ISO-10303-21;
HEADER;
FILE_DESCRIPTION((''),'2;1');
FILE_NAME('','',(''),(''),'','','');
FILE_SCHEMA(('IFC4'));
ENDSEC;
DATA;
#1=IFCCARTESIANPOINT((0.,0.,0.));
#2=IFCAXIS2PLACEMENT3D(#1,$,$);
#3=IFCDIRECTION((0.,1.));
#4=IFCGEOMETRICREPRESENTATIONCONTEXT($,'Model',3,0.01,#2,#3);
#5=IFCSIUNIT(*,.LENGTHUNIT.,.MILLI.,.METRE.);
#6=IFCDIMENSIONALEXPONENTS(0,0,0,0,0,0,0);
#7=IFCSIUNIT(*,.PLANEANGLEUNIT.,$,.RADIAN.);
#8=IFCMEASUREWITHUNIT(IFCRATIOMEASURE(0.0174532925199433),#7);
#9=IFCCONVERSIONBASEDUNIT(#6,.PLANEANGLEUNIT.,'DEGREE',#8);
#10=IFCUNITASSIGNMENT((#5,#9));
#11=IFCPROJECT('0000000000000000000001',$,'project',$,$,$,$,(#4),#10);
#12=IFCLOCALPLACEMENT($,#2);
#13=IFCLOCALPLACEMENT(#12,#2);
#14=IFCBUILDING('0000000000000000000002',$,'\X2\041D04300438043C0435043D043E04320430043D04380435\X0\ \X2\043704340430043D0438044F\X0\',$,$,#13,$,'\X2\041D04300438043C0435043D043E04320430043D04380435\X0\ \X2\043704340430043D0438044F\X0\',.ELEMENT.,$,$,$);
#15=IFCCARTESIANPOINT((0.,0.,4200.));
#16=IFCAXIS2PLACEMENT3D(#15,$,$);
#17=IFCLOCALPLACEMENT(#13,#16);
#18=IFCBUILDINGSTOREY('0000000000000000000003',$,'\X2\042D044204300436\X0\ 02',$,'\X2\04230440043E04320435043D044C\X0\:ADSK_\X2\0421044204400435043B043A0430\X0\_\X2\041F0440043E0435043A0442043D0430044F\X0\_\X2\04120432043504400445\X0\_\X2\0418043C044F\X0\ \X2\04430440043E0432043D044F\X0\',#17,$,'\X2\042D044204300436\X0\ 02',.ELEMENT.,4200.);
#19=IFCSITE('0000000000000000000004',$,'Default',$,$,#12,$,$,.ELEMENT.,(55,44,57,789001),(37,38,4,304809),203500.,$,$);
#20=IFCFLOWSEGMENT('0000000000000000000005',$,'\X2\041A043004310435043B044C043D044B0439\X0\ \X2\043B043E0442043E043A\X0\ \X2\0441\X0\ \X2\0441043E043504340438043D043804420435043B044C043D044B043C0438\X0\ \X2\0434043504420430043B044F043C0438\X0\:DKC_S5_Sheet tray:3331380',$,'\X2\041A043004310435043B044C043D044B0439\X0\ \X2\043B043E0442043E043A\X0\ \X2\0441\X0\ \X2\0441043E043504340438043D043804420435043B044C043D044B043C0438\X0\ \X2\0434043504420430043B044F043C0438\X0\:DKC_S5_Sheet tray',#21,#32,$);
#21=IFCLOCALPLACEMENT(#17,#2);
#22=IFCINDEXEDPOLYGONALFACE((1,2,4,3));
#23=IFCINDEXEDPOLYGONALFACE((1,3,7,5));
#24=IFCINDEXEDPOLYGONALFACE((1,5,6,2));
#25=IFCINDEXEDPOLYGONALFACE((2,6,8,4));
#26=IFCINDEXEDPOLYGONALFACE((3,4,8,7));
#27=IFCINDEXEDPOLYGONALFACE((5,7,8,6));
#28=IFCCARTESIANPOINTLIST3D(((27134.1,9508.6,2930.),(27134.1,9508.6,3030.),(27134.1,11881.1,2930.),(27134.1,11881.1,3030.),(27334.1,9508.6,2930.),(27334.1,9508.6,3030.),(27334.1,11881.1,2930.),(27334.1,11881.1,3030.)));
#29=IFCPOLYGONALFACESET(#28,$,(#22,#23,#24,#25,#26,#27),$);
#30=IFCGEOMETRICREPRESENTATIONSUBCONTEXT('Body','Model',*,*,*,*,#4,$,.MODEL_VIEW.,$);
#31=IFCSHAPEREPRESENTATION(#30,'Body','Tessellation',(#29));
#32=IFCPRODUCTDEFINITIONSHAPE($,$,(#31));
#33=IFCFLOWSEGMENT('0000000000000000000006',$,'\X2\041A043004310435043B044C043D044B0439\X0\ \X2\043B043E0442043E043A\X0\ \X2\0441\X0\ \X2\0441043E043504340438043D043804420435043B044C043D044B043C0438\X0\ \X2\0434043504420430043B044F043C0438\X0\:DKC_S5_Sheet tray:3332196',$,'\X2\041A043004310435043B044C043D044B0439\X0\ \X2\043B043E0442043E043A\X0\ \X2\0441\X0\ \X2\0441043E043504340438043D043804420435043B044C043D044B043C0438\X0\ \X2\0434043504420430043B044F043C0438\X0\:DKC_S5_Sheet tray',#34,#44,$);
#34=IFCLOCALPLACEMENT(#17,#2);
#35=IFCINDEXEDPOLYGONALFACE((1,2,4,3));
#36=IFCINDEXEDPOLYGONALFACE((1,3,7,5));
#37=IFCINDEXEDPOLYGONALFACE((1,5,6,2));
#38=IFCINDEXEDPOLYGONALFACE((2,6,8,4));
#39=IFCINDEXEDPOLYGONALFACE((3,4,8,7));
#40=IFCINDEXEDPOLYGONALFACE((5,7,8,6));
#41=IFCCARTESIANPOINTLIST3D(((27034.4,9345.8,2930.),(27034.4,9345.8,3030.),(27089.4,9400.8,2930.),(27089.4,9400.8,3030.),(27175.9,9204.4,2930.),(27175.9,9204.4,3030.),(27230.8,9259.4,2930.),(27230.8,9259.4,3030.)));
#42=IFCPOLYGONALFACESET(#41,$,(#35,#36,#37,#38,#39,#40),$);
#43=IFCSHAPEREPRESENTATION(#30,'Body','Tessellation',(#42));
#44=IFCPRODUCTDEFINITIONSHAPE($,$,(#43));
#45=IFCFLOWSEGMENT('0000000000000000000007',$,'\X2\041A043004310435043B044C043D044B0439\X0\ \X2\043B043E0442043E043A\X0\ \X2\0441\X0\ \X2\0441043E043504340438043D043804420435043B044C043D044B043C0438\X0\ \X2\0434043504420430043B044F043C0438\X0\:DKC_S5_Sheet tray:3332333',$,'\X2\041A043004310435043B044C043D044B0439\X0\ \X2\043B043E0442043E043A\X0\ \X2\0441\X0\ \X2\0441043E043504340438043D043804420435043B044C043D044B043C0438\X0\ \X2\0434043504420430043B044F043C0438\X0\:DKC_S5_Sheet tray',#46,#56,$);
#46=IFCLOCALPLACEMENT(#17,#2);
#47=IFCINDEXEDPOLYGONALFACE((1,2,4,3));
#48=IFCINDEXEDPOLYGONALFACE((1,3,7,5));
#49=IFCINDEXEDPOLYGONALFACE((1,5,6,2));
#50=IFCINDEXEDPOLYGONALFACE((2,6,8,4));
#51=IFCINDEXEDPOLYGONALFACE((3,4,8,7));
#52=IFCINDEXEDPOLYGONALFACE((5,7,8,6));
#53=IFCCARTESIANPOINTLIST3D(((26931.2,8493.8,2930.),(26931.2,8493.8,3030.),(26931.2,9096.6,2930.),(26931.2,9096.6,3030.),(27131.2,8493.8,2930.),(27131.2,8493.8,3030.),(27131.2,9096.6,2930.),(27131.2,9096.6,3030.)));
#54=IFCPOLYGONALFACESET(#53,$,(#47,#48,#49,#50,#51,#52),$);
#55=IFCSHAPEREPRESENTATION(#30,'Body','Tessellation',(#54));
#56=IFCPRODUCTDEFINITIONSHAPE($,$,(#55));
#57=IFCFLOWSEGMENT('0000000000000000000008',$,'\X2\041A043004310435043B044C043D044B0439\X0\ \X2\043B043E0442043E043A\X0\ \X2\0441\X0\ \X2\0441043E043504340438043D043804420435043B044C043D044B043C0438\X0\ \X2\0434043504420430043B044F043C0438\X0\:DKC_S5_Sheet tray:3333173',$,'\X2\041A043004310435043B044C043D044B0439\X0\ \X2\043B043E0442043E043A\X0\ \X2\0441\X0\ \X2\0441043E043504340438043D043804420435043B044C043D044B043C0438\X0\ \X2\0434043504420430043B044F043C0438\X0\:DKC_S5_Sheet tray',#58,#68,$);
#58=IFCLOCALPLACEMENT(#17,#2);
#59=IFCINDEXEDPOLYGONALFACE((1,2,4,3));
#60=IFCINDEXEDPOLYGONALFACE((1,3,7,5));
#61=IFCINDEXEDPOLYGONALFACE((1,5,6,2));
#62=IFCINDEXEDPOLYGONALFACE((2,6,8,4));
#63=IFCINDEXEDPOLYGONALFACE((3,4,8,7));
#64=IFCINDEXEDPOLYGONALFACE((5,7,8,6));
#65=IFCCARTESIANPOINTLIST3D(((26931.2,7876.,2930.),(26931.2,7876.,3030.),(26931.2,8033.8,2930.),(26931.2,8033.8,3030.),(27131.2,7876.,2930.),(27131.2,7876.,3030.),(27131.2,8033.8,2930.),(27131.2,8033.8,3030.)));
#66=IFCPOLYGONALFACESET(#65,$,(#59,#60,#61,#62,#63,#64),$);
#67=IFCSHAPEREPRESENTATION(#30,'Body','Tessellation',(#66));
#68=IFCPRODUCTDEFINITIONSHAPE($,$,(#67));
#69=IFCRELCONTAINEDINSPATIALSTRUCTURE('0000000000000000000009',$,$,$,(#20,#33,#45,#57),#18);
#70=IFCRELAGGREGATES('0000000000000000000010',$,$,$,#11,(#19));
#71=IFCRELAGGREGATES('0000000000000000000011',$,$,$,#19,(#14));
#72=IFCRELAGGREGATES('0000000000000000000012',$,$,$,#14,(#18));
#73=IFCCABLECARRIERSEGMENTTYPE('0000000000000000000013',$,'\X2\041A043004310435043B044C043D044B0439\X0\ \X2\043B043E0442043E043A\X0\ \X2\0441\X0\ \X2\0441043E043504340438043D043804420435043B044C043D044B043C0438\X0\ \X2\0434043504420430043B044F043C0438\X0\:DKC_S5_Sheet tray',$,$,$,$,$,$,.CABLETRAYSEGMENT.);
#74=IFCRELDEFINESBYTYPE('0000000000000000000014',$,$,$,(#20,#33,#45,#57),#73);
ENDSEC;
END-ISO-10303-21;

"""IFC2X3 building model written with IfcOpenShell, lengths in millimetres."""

from ifc_helpers import new_model, entity, si_unit, converted_unit, direction, frame, frame_2d, origin, origin_2d_with_axis, place, context, subcontext, project, spatial, rectangle, extrude, type_object, element, save


model = new_model("IFC2X3")

# Units and contexts
model_context = context("Model", 3, precision=0.01, world=origin(), true_north=direction((0.0, 1.0)))
body_context = subcontext(model_context, "Body", "Model", "MODEL_VIEW")
ifc_project = project(units=[si_unit("LENGTHUNIT", "METRE", prefix="MILLI"), converted_unit("PLANEANGLEUNIT", "DEGREE", entity("IfcRatioMeasure", 0.0174532925199433), si_unit("PLANEANGLEUNIT", "RADIAN"), dimensions=[0, 0, 0, 0, 0, 0, 0])], contexts=[model_context])

# Site, building, storey
site_placement = place(None, frame((0.0, 0.0, 0.0)))
site = spatial("IfcSite", under=ifc_project, at=site_placement, Name="Default", CompositionType="ELEMENT", RefLatitude=(55, 44, 57, 789001), RefLongitude=(37, 38, 4, 304809), RefElevation=203500.0)
building_placement = place(site_placement, origin())
building = spatial("IfcBuilding", under=site, at=building_placement, Name="Наименование здания", LongName="Наименование здания", CompositionType="ELEMENT")
storey_placement = place(building_placement, frame((0.0, 0.0, 4200.0)))
storey = spatial("IfcBuildingStorey", under=building, at=storey_placement, Name="Этаж 02", ObjectType="Уровень:ADSK_Стрелка_Проектная_Вверх_Имя уровня", LongName="Этаж 02", CompositionType="ELEMENT", Elevation=4200.0)

# Flow segments
cable_carrier_segment_type = type_object("IfcCableCarrierSegmentType", Name="Кабельный лоток с соединительными деталями:DKC_S5_Sheet tray", PredefinedType="CABLETRAYSEGMENT")
flow_segment_1_placement = place(storey_placement, frame((27134.1, 9508.6, 2930.0)))
element("IfcFlowSegment", 1, at=flow_segment_1_placement, inside=storey, type_object=cable_carrier_segment_type, Name="Кабельный лоток с соединительными деталями:DKC_S5_Sheet tray:3331380", ObjectType="Кабельный лоток с соединительными деталями:DKC_S5_Sheet tray", context=body_context, shape_type="SweptSolid", body=[
    extrude(rectangle(XDim=2372.5, YDim=200.0, at=origin_2d_with_axis()), frame((100.0, 1186.3, 0.0), z_axis=(0.0, 0.0, 1.0), x_axis=(0.0, -1.0, 0.0)), (0.0, 0.0, 1.0), 100.0),
])
flow_segment_2_placement = place(storey_placement, frame((27034.4, 9204.4, 2930.0)))
element("IfcFlowSegment", 2, at=flow_segment_2_placement, inside=storey, type_object=cable_carrier_segment_type, Name="Кабельный лоток с соединительными деталями:DKC_S5_Sheet tray:3332196", ObjectType="Кабельный лоток с соединительными деталями:DKC_S5_Sheet tray", context=body_context, shape_type="SweptSolid", body=[
    extrude(rectangle(XDim=77.8, YDim=200.0, at=frame_2d((0.0, 0.0), x_axis=(1.0, 0.0))), frame((98.2, 98.2, 0.0), z_axis=(0.0, 0.0, 1.0), x_axis=(-0.707107, -0.707107, 0.0)), (0.0, 0.0, 1.0), 100.0),
])
flow_segment_3_placement = place(storey_placement, frame((26931.2, 8493.8, 2930.0)))
element("IfcFlowSegment", 3, at=flow_segment_3_placement, inside=storey, type_object=cable_carrier_segment_type, Name="Кабельный лоток с соединительными деталями:DKC_S5_Sheet tray:3332333", ObjectType="Кабельный лоток с соединительными деталями:DKC_S5_Sheet tray", context=body_context, shape_type="SweptSolid", body=[
    extrude(rectangle(XDim=602.8, YDim=200.0, at=frame_2d((0.0, 0.0), x_axis=(1.0, 0.0))), frame((100.0, 301.4, 0.0), z_axis=(0.0, 0.0, 1.0), x_axis=(0.0, -1.0, 0.0)), (0.0, 0.0, 1.0), 100.0),
])
flow_segment_4_placement = place(storey_placement, frame((26931.2, 7876.0, 2930.0)))
element("IfcFlowSegment", 4, at=flow_segment_4_placement, inside=storey, type_object=cable_carrier_segment_type, Name="Кабельный лоток с соединительными деталями:DKC_S5_Sheet tray:3333173", ObjectType="Кабельный лоток с соединительными деталями:DKC_S5_Sheet tray", context=body_context, shape_type="SweptSolid", body=[
    extrude(rectangle(XDim=157.8, YDim=200.0, at=origin_2d_with_axis()), frame((100.0, 78.9, 0.0), z_axis=(0.0, 0.0, 1.0), x_axis=(0.0, -1.0, 0.0)), (0.0, 0.0, 1.0), 100.0),
])

save(model, "model.ifc")
